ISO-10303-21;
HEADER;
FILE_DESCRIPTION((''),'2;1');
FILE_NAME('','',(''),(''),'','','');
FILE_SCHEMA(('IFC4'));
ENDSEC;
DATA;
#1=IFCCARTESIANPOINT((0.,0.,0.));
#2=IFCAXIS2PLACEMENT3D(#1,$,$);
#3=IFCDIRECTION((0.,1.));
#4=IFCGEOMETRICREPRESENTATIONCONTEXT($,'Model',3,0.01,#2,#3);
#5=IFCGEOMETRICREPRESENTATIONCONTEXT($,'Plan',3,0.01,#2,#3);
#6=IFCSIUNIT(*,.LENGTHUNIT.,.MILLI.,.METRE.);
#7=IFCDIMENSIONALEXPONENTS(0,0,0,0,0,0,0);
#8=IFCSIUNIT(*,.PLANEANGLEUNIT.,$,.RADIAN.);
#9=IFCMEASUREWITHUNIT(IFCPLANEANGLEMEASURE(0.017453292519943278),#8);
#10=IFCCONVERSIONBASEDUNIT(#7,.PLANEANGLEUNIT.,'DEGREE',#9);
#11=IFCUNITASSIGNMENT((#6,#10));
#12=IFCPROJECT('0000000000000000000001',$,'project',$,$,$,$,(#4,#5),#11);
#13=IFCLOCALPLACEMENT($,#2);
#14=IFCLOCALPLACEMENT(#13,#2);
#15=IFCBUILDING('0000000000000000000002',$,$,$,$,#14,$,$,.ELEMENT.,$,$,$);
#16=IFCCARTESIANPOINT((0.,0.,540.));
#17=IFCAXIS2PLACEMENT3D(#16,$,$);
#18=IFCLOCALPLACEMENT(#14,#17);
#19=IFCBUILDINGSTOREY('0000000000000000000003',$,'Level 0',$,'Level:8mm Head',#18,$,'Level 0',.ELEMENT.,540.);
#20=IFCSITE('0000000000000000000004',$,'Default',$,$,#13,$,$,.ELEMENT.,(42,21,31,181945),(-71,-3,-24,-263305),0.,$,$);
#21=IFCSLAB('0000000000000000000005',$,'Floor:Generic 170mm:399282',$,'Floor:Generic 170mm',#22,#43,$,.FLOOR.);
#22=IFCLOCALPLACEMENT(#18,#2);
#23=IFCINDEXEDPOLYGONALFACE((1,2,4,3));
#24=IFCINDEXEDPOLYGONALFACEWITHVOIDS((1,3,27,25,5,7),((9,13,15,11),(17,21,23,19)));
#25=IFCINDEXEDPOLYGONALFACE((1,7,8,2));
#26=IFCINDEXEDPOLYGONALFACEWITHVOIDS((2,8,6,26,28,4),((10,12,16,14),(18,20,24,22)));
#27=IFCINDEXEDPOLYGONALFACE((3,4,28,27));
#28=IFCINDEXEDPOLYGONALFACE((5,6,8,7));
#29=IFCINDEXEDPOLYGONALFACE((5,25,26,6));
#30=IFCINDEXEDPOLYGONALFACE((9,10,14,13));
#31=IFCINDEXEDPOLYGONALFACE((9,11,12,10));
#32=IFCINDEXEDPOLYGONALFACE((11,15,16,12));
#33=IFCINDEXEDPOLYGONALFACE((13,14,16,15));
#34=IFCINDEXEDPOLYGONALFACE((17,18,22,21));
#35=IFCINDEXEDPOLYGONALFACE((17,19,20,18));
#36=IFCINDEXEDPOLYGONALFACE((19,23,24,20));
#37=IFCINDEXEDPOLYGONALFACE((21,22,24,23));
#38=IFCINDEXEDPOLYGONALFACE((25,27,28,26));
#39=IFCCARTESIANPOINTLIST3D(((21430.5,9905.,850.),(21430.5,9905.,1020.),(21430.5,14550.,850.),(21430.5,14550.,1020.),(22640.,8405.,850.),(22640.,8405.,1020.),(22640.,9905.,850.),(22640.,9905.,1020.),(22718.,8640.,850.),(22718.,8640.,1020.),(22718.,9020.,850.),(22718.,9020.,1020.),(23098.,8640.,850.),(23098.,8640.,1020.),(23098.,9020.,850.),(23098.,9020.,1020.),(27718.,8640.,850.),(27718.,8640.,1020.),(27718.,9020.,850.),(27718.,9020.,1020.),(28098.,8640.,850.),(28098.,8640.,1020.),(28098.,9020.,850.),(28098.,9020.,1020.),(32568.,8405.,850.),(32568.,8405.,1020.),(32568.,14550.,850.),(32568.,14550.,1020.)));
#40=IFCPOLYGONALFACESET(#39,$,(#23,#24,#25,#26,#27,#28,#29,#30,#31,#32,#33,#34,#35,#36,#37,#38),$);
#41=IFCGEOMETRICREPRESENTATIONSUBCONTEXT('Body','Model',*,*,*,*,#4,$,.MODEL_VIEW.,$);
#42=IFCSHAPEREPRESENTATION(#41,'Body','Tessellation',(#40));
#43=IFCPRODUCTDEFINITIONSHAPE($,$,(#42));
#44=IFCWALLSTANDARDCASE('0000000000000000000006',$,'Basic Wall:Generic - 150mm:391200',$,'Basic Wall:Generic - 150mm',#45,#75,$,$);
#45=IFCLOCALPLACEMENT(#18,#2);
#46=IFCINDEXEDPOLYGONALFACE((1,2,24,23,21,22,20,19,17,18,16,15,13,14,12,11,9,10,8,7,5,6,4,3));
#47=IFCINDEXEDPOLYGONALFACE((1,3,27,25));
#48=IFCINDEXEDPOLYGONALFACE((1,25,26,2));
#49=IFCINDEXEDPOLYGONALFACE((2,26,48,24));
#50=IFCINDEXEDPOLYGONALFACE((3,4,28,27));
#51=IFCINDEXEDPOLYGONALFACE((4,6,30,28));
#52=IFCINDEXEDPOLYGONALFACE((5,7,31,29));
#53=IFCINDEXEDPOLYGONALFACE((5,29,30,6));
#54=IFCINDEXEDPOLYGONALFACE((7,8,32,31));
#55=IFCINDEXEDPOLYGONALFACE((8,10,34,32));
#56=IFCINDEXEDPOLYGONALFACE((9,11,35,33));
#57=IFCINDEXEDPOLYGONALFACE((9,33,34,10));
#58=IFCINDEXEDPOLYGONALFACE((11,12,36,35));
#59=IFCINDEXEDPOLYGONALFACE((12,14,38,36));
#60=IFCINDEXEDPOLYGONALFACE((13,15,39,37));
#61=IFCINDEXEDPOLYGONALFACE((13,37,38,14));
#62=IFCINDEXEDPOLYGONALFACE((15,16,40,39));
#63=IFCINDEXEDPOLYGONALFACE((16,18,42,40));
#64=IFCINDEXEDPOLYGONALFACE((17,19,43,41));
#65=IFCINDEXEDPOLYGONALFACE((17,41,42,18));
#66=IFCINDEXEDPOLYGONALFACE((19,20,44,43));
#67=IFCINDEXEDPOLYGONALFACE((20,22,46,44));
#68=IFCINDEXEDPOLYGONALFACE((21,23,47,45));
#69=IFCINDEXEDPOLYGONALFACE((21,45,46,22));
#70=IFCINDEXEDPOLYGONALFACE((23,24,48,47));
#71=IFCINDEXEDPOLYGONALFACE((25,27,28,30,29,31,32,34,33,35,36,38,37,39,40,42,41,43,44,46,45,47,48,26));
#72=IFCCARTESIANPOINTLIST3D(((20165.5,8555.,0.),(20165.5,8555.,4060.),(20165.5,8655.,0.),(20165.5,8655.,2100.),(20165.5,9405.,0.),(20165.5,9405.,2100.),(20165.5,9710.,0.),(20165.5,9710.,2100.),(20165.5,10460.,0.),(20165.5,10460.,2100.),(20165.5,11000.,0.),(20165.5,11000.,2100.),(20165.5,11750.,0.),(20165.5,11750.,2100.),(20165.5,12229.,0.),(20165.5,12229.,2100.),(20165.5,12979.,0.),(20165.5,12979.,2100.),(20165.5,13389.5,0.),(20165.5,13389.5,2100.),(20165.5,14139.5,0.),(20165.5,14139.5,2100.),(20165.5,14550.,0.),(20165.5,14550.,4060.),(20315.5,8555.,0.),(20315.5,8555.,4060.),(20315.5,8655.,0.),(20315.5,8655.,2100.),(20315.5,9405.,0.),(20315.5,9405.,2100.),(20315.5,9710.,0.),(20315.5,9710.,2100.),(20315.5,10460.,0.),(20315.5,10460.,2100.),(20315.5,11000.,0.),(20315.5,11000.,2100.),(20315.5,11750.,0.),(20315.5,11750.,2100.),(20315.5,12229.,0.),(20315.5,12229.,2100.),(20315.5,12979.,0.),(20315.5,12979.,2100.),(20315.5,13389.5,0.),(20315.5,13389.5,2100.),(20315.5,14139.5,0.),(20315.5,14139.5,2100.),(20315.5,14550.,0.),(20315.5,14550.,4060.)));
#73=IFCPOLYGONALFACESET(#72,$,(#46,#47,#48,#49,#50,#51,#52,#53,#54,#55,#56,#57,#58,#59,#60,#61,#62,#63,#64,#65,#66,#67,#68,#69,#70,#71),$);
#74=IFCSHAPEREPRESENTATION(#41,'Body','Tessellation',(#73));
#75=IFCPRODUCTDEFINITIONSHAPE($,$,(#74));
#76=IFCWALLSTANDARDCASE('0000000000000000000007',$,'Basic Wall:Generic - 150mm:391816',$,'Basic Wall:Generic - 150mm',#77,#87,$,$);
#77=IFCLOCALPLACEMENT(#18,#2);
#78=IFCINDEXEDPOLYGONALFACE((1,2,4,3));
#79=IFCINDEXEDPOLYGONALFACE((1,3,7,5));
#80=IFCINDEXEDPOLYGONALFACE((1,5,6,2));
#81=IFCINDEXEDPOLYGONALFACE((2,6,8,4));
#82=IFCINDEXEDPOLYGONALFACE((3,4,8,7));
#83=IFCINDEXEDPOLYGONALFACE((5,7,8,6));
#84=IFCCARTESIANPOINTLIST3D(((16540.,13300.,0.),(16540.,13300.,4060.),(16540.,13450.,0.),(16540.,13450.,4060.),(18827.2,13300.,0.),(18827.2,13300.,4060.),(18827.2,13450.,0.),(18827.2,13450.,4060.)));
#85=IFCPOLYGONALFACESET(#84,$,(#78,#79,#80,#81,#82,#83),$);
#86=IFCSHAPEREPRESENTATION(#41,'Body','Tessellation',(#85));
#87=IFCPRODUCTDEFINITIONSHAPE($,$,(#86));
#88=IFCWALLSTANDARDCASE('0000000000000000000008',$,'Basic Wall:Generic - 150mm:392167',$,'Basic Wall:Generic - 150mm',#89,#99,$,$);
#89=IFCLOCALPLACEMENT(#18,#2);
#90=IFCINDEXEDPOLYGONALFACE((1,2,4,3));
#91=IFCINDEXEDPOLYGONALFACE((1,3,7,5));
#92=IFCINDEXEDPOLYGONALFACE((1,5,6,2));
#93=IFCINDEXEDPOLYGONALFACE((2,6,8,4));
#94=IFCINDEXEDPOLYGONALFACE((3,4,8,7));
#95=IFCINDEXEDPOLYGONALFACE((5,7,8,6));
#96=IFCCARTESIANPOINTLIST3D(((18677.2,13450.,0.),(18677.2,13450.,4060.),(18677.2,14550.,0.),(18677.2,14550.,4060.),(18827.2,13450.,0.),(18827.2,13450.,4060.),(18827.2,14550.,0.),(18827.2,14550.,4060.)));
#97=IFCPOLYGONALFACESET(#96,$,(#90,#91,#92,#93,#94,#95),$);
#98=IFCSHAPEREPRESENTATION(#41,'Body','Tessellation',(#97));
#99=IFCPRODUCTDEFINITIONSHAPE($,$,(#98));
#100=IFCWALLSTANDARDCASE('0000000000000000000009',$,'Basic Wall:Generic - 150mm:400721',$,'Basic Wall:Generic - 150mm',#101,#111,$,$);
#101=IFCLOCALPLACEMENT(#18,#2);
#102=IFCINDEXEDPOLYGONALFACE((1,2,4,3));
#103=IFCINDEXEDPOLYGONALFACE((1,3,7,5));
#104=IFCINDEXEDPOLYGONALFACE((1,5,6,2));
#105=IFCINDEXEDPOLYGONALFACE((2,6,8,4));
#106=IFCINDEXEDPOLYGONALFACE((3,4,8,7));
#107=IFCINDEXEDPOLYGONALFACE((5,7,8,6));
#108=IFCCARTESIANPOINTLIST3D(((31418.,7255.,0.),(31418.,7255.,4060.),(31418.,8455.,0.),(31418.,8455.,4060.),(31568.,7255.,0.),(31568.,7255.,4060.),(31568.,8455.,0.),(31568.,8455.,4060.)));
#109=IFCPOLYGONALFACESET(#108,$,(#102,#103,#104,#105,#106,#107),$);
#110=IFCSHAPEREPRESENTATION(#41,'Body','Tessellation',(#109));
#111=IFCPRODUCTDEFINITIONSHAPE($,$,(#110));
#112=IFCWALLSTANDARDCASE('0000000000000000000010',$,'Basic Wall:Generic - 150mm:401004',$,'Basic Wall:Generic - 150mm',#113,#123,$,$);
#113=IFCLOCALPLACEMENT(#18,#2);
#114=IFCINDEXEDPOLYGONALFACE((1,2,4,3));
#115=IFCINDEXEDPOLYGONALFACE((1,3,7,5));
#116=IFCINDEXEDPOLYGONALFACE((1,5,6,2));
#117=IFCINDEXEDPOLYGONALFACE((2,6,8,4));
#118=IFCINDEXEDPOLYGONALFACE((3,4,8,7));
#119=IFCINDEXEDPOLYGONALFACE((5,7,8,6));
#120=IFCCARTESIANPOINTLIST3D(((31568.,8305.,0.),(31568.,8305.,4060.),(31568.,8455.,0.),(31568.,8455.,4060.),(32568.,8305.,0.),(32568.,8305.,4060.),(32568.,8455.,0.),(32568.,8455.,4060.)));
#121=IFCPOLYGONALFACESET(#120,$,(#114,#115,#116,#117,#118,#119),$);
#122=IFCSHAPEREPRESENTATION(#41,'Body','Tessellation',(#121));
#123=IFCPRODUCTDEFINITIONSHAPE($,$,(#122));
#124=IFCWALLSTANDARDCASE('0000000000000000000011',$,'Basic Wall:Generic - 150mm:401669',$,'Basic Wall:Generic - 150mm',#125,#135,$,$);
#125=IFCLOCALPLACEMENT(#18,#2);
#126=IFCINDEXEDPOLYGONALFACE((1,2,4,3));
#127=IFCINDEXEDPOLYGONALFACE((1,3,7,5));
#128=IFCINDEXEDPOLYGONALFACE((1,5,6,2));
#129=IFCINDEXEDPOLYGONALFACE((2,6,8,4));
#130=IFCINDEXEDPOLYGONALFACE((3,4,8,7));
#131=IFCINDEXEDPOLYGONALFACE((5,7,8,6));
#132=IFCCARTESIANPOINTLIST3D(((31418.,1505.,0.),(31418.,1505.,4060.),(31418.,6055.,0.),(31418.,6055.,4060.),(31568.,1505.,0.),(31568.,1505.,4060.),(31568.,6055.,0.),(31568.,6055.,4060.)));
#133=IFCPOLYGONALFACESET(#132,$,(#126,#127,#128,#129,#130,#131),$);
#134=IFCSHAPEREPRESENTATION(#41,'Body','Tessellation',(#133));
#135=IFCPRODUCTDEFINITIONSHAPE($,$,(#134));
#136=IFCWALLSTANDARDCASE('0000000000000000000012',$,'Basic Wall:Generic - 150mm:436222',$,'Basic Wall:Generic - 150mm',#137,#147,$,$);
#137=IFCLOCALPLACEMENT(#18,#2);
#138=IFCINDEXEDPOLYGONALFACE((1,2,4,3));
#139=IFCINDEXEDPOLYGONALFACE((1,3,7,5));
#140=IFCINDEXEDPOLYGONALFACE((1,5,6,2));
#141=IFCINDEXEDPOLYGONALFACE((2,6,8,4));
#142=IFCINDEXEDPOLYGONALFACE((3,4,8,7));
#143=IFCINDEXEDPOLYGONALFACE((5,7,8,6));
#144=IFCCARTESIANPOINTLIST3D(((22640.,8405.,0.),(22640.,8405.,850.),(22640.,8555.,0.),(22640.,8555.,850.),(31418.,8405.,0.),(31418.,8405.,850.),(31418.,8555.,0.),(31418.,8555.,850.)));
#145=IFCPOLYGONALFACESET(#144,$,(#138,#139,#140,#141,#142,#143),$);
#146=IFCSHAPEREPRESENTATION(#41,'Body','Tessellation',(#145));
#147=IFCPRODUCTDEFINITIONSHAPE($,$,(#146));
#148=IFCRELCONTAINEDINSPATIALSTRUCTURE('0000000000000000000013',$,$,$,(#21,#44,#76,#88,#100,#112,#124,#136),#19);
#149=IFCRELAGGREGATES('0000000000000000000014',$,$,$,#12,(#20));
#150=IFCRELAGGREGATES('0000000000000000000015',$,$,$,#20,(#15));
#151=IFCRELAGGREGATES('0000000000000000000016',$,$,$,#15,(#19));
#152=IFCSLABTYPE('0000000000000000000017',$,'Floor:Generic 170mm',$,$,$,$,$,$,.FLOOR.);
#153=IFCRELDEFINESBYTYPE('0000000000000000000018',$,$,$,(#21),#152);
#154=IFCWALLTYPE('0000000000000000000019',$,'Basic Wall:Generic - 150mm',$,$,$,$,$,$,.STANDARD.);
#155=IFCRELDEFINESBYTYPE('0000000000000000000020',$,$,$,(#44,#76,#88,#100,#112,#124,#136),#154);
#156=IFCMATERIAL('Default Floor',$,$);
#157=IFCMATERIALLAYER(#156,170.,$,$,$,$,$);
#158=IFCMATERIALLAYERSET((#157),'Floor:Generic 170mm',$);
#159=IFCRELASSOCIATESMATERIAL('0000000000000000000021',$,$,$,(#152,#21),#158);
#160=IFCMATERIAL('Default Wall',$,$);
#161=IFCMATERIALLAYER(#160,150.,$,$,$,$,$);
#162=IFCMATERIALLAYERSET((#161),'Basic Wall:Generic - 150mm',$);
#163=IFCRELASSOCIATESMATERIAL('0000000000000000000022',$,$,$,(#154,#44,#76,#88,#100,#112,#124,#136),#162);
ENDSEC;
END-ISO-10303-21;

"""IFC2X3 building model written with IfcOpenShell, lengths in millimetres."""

from ifc_helpers import new_model, entity, si_unit, converted_unit, direction, frame, frame_2d, origin, place, context, subcontext, project, spatial, polyline, rectangle, outline, extrude, clip, bounded_halfspace, material, layer, layer_set, layer_usage, type_object, element, save


model = new_model("IFC2X3")

# Units and contexts
model_context = context("Model", 3, precision=0.01, world=origin(), true_north=direction((0.0, 1.0)))
plan_context = context("Plan", 3, precision=0.01, world=origin(), true_north=direction((0.0, 1.0)))
body_context = subcontext(model_context, "Body", "Model", "MODEL_VIEW")
ifc_project = project(units=[si_unit("LENGTHUNIT", "METRE", prefix="MILLI"), converted_unit("PLANEANGLEUNIT", "DEGREE", entity("IfcPlaneAngleMeasure", 0.017453292519943278), si_unit("PLANEANGLEUNIT", "RADIAN"), dimensions=[0, 0, 0, 0, 0, 0, 0])], contexts=[model_context, plan_context])

# Site, building, storey
site_placement = place(None, origin())
site = spatial("IfcSite", under=ifc_project, at=site_placement, Name="Default", CompositionType="ELEMENT", RefLatitude=(42, 21, 31, 181945), RefLongitude=(-71, -3, -24, -263305), RefElevation=0.0)
building_placement = place(site_placement, origin())
building = spatial("IfcBuilding", under=site, at=building_placement, CompositionType="ELEMENT")
storey_placement = place(building_placement, frame((0.0, 0.0, 540.0)))
storey = spatial("IfcBuildingStorey", under=building, at=storey_placement, Name="Level 0", ObjectType="Level:8mm Head", LongName="Level 0", CompositionType="ELEMENT", Elevation=540.0)

# Slab, openings
ifc_material_1 = material(Name="Default Floor")
ifc_layer_1 = layer(ifc_material_1, 170.0)
ifc_layer_set_1 = layer_set([ifc_layer_1], Name="Floor:Generic 170mm")
ifc_layer_usage_1 = layer_usage(ifc_layer_set_1, "AXIS3", "POSITIVE", 0.0)
slab_type = type_object("IfcSlabType", Name="Floor:Generic 170mm", PredefinedType="FLOOR", material=ifc_layer_set_1)
slab_placement = place(storey_placement, frame((21430.5, 8405.0, 850.0)))
slab = element("IfcSlab", 1, at=slab_placement, inside=storey, type_object=slab_type, material=ifc_layer_usage_1, Name="Floor:Generic 170mm:399282", ObjectType="Floor:Generic 170mm", PredefinedType="FLOOR", context=body_context, shape_type="SweptSolid", body=[
    extrude(outline(polyline([(-5568.7, 3072.5), (-5568.7, -3072.5), (4359.2, -3072.5), (4359.2, -1572.5), (5568.7, -1572.5), (5568.7, 3072.5), (-5568.7, 3072.5)])), frame((5568.7, 3072.5, 170.0), z_axis=(0.0, 0.0, -1.0), x_axis=(-1.0, 0.0, 0.0)), (0.0, 0.0, 1.0), 170.0),
])
opening_1_placement = place(slab_placement, origin())
element("IfcOpeningElement", 2, at=opening_1_placement, cuts=slab, ObjectType="Opening", context=body_context, shape_type="SweptSolid", body=[
    extrude(rectangle(XDim=380.0, YDim=380.0, at=frame_2d((0.0, 0.0), x_axis=(1.0, 0.0))), frame((1477.4, 425.0, 170.0), z_axis=(0.0, 0.0, -1.0), x_axis=(0.0, -1.0, 0.0)), (0.0, 0.0, 1.0), 170.0),
])
opening_2_placement = place(slab_placement, origin())
element("IfcOpeningElement", 3, at=opening_2_placement, cuts=slab, ObjectType="Opening", context=body_context, shape_type="SweptSolid", body=[
    extrude(rectangle(XDim=380.0, YDim=380.0, at=frame_2d((0.0, 0.0), x_axis=(1.0, 0.0))), frame((6477.4, 425.0, 170.0), z_axis=(0.0, 0.0, -1.0), x_axis=(0.0, -1.0, 0.0)), (0.0, 0.0, 1.0), 170.0),
])

# Shared definitions
ifc_material_2 = material(Name="Default Wall")
ifc_layer_2 = layer(ifc_material_2, 150.0)
ifc_layer_set_2 = layer_set([ifc_layer_2], Name="Basic Wall:Generic - 150mm")
ifc_layer_usage_2 = layer_usage(ifc_layer_set_2, "AXIS2", "NEGATIVE", 75.0)
wall_type_1 = type_object("IfcWallType", Name="Basic Wall:Generic - 150mm", PredefinedType="STANDARD", material=ifc_layer_set_2)

# Wall, openings
wall_1_placement = place(storey_placement, frame((20240.5, 14550.0, 0.0), z_axis=(0.0, 0.0, 1.0), x_axis=(0.0, -1.0, 0.0)))
wall_1 = element("IfcWallStandardCase", 4, at=wall_1_placement, inside=storey, type_object=wall_type_1, material=ifc_layer_usage_2, Name="Basic Wall:Generic - 150mm:391200", ObjectType="Basic Wall:Generic - 150mm", context=body_context, shape_type="Clipping", body=[
    clip(extrude(rectangle(XDim=5995.0, YDim=150.0, at=frame_2d((2997.5, 0.0), x_axis=(-1.0, 0.0))), origin(), (0.0, 0.0, 1.0), 4060.0), bounded_halfspace(frame((0.0, -75.0, 4060.0), z_axis=(0.0, 0.0, -1.0), x_axis=(1.0, 0.0, 0.0)), True, frame((0.0, -75.0, 4060.0)), polyline([(0.0, 0.0), (2721.0, 0.0), (2800.0, 0.0), (3990.0, 0.0), (4069.0, 0.0), (5995.0, 0.0), (5995.0, 150.0), (4945.0, 150.0), (4866.0, 150.0), (3653.0, 150.0), (3574.0, 150.0), (2462.0, 150.0), (2383.0, 150.0), (1270.0, 150.0), (1191.0, 150.0), (0.0, 150.0), (0.0, 0.0)]))),
])
opening_3_placement = place(wall_1_placement, frame((1571.0, -75.0, 0.0)))
element("IfcOpeningElement", 5, at=opening_3_placement, cuts=wall_1, ObjectType="Opening", context=body_context, shape_type="SweptSolid", body=[
    extrude(rectangle(XDim=2100.0, YDim=750.0, at=frame_2d((1050.0, 375.0), x_axis=(1.0, 0.0))), frame((0.0, 0.0, 0.0), z_axis=(0.0, 1.0, 0.0), x_axis=(0.0, 0.0, 1.0)), (0.0, 0.0, 1.0), 150.0),
])
opening_4_placement = place(wall_1_placement, frame((2800.0, -75.0, 0.0)))
element("IfcOpeningElement", 6, at=opening_4_placement, cuts=wall_1, ObjectType="Opening", context=body_context, shape_type="SweptSolid", body=[
    extrude(rectangle(XDim=2100.0, YDim=750.0, at=frame_2d((1050.0, 375.0), x_axis=(1.0, 0.0))), frame((0.0, 0.0, 0.0), z_axis=(0.0, 1.0, 0.0), x_axis=(0.0, 0.0, 1.0)), (0.0, 0.0, 1.0), 150.0),
])
opening_5_placement = place(wall_1_placement, frame((4090.0, -75.0, 0.0)))
element("IfcOpeningElement", 7, at=opening_5_placement, cuts=wall_1, ObjectType="Opening", context=body_context, shape_type="SweptSolid", body=[
    extrude(rectangle(XDim=2100.0, YDim=750.0, at=frame_2d((1050.0, 375.0), x_axis=(1.0, 0.0))), frame((0.0, 0.0, 0.0), z_axis=(0.0, 1.0, 0.0), x_axis=(0.0, 0.0, 1.0)), (0.0, 0.0, 1.0), 150.0),
])
opening_6_placement = place(wall_1_placement, frame((5145.0, -75.0, 0.0)))
element("IfcOpeningElement", 8, at=opening_6_placement, cuts=wall_1, ObjectType="Opening", context=body_context, shape_type="SweptSolid", body=[
    extrude(rectangle(XDim=2100.0, YDim=750.0, at=frame_2d((1050.0, 375.0), x_axis=(1.0, 0.0))), frame((0.0, 0.0, 0.0), z_axis=(0.0, 1.0, 0.0), x_axis=(0.0, 0.0, 1.0)), (0.0, 0.0, 1.0), 150.0),
])
opening_7_placement = place(wall_1_placement, frame((410.5, -75.0, 0.0)))
element("IfcOpeningElement", 9, at=opening_7_placement, cuts=wall_1, ObjectType="Opening", context=body_context, shape_type="SweptSolid", body=[
    extrude(rectangle(XDim=2100.0, YDim=750.0, at=frame_2d((1050.0, 375.0), x_axis=(1.0, 0.0))), frame((0.0, 0.0, 0.0), z_axis=(0.0, 1.0, 0.0), x_axis=(0.0, 0.0, 1.0)), (0.0, 0.0, 1.0), 150.0),
])

# Walls
wall_2_placement = place(storey_placement, frame((18827.2, 13375.0, 0.0), z_axis=(0.0, 0.0, 1.0), x_axis=(-1.0, 0.0, 0.0)))
element("IfcWallStandardCase", 10, at=wall_2_placement, inside=storey, type_object=wall_type_1, material=ifc_layer_usage_2, Name="Basic Wall:Generic - 150mm:391816", ObjectType="Basic Wall:Generic - 150mm", context=body_context, shape_type="Clipping", body=[
    clip(extrude(rectangle(XDim=2287.2, YDim=150.0, at=frame_2d((1143.6, 0.0), x_axis=(-1.0, 0.0))), origin(), (0.0, 0.0, 1.0), 4060.0), bounded_halfspace(frame((0.0, -75.0, 4060.0), z_axis=(0.0, 0.0, -1.0), x_axis=(0.0, 1.0, 0.0)), True, frame((0.0, -75.0, 4060.0)), polyline([(0.0, 0.0), (150.0, 0.0), (2287.2, 0.0), (2287.2, 150.0), (79.0, 150.0), (0.0, 150.0), (0.0, 0.0)]))),
])
wall_3_placement = place(storey_placement, frame((18752.2, 14550.0, 0.0), z_axis=(0.0, 0.0, 1.0), x_axis=(0.0, -1.0, 0.0)))
element("IfcWallStandardCase", 11, at=wall_3_placement, inside=storey, type_object=wall_type_1, material=ifc_layer_usage_2, Name="Basic Wall:Generic - 150mm:392167", ObjectType="Basic Wall:Generic - 150mm", context=body_context, shape_type="Clipping", body=[
    clip(extrude(rectangle(XDim=1100.0, YDim=150.0, at=frame_2d((550.0, 0.0), x_axis=(-1.0, 0.0))), origin(), (0.0, 0.0, 1.0), 4060.0), bounded_halfspace(frame((0.0, -75.0, 4060.0), z_axis=(0.0, 0.0, -1.0), x_axis=(1.0, 0.0, 0.0)), True, frame((0.0, -75.0, 4060.0)), polyline([(0.0, 0.0), (1100.0, 0.0), (1100.0, 150.0), (0.0, 150.0), (0.0, 0.0)]))),
])
wall_4_placement = place(storey_placement, frame((31493.0, 8455.0, 0.0), z_axis=(0.0, 0.0, 1.0), x_axis=(0.0, -1.0, 0.0)))
element("IfcWallStandardCase", 12, at=wall_4_placement, inside=storey, type_object=wall_type_1, material=ifc_layer_usage_2, Name="Basic Wall:Generic - 150mm:400721", ObjectType="Basic Wall:Generic - 150mm", context=body_context, shape_type="Clipping", body=[
    clip(extrude(rectangle(XDim=1200.0, YDim=150.0, at=frame_2d((600.0, 0.0), x_axis=(-1.0, 0.0))), origin(), (0.0, 0.0, 1.0), 4060.0), bounded_halfspace(frame((0.0, -75.0, 4060.0), z_axis=(0.0, 0.0, -1.0), x_axis=(1.0, 0.0, 0.0)), True, frame((0.0, -75.0, 4060.0)), polyline([(0.0, 0.0), (1200.0, 0.0), (1200.0, 150.0), (150.0, 150.0), (0.0, 150.0), (0.0, 0.0)]))),
])
wall_5_placement = place(storey_placement, frame((31568.0, 8380.0, 0.0)))
element("IfcWallStandardCase", 13, at=wall_5_placement, inside=storey, type_object=wall_type_1, material=ifc_layer_usage_2, Name="Basic Wall:Generic - 150mm:401004", ObjectType="Basic Wall:Generic - 150mm", context=body_context, shape_type="Clipping", body=[
    clip(extrude(rectangle(XDim=1000.0, YDim=150.0, at=frame_2d((500.0, 0.0), x_axis=(-1.0, 0.0))), origin(), (0.0, 0.0, 1.0), 4060.0), bounded_halfspace(frame((0.0, -75.0, 4060.0), z_axis=(0.0, 0.0, -1.0), x_axis=(0.0, -1.0, 0.0)), True, frame((0.0, -75.0, 4060.0)), polyline([(0.0, 0.0), (1000.0, 0.0), (1000.0, 150.0), (0.0, 150.0), (0.0, 0.0)]))),
])
wall_6_placement = place(storey_placement, frame((31493.0, 6055.0, 0.0), z_axis=(0.0, 0.0, 1.0), x_axis=(0.0, -1.0, 0.0)))
element("IfcWallStandardCase", 14, at=wall_6_placement, inside=storey, type_object=wall_type_1, material=ifc_layer_usage_2, Name="Basic Wall:Generic - 150mm:401669", ObjectType="Basic Wall:Generic - 150mm", context=body_context, shape_type="Clipping", body=[
    clip(extrude(rectangle(XDim=4550.0, YDim=150.0, at=frame_2d((2275.0, 0.0), x_axis=(-1.0, 0.0))), origin(), (0.0, 0.0, 1.0), 4060.0), bounded_halfspace(frame((0.0, -75.0, 4060.0), z_axis=(0.0, 0.0, -1.0), x_axis=(1.0, 0.0, 0.0)), True, frame((0.0, -75.0, 4060.0)), polyline([(0.0, 0.0), (4550.0, 0.0), (4550.0, 150.0), (0.0, 150.0), (0.0, 0.0)]))),
])
ifc_layer_usage_3 = layer_usage(ifc_layer_set_2, "AXIS2", "POSITIVE", -75.0)
wall_7_placement = place(storey_placement, frame((22640.0, 8480.0, 0.0)))
element("IfcWallStandardCase", 15, at=wall_7_placement, inside=storey, type_object=wall_type_1, material=ifc_layer_usage_3, Name="Basic Wall:Generic - 150mm:436222", ObjectType="Basic Wall:Generic - 150mm", context=body_context, shape_type="SweptSolid", body=[
    extrude(rectangle(XDim=8778.0, YDim=150.0, at=frame_2d((4389.0, 0.0), x_axis=(-1.0, 0.0))), origin(), (0.0, 0.0, 1.0), 850.0),
])

save(model, "model.ifc")
